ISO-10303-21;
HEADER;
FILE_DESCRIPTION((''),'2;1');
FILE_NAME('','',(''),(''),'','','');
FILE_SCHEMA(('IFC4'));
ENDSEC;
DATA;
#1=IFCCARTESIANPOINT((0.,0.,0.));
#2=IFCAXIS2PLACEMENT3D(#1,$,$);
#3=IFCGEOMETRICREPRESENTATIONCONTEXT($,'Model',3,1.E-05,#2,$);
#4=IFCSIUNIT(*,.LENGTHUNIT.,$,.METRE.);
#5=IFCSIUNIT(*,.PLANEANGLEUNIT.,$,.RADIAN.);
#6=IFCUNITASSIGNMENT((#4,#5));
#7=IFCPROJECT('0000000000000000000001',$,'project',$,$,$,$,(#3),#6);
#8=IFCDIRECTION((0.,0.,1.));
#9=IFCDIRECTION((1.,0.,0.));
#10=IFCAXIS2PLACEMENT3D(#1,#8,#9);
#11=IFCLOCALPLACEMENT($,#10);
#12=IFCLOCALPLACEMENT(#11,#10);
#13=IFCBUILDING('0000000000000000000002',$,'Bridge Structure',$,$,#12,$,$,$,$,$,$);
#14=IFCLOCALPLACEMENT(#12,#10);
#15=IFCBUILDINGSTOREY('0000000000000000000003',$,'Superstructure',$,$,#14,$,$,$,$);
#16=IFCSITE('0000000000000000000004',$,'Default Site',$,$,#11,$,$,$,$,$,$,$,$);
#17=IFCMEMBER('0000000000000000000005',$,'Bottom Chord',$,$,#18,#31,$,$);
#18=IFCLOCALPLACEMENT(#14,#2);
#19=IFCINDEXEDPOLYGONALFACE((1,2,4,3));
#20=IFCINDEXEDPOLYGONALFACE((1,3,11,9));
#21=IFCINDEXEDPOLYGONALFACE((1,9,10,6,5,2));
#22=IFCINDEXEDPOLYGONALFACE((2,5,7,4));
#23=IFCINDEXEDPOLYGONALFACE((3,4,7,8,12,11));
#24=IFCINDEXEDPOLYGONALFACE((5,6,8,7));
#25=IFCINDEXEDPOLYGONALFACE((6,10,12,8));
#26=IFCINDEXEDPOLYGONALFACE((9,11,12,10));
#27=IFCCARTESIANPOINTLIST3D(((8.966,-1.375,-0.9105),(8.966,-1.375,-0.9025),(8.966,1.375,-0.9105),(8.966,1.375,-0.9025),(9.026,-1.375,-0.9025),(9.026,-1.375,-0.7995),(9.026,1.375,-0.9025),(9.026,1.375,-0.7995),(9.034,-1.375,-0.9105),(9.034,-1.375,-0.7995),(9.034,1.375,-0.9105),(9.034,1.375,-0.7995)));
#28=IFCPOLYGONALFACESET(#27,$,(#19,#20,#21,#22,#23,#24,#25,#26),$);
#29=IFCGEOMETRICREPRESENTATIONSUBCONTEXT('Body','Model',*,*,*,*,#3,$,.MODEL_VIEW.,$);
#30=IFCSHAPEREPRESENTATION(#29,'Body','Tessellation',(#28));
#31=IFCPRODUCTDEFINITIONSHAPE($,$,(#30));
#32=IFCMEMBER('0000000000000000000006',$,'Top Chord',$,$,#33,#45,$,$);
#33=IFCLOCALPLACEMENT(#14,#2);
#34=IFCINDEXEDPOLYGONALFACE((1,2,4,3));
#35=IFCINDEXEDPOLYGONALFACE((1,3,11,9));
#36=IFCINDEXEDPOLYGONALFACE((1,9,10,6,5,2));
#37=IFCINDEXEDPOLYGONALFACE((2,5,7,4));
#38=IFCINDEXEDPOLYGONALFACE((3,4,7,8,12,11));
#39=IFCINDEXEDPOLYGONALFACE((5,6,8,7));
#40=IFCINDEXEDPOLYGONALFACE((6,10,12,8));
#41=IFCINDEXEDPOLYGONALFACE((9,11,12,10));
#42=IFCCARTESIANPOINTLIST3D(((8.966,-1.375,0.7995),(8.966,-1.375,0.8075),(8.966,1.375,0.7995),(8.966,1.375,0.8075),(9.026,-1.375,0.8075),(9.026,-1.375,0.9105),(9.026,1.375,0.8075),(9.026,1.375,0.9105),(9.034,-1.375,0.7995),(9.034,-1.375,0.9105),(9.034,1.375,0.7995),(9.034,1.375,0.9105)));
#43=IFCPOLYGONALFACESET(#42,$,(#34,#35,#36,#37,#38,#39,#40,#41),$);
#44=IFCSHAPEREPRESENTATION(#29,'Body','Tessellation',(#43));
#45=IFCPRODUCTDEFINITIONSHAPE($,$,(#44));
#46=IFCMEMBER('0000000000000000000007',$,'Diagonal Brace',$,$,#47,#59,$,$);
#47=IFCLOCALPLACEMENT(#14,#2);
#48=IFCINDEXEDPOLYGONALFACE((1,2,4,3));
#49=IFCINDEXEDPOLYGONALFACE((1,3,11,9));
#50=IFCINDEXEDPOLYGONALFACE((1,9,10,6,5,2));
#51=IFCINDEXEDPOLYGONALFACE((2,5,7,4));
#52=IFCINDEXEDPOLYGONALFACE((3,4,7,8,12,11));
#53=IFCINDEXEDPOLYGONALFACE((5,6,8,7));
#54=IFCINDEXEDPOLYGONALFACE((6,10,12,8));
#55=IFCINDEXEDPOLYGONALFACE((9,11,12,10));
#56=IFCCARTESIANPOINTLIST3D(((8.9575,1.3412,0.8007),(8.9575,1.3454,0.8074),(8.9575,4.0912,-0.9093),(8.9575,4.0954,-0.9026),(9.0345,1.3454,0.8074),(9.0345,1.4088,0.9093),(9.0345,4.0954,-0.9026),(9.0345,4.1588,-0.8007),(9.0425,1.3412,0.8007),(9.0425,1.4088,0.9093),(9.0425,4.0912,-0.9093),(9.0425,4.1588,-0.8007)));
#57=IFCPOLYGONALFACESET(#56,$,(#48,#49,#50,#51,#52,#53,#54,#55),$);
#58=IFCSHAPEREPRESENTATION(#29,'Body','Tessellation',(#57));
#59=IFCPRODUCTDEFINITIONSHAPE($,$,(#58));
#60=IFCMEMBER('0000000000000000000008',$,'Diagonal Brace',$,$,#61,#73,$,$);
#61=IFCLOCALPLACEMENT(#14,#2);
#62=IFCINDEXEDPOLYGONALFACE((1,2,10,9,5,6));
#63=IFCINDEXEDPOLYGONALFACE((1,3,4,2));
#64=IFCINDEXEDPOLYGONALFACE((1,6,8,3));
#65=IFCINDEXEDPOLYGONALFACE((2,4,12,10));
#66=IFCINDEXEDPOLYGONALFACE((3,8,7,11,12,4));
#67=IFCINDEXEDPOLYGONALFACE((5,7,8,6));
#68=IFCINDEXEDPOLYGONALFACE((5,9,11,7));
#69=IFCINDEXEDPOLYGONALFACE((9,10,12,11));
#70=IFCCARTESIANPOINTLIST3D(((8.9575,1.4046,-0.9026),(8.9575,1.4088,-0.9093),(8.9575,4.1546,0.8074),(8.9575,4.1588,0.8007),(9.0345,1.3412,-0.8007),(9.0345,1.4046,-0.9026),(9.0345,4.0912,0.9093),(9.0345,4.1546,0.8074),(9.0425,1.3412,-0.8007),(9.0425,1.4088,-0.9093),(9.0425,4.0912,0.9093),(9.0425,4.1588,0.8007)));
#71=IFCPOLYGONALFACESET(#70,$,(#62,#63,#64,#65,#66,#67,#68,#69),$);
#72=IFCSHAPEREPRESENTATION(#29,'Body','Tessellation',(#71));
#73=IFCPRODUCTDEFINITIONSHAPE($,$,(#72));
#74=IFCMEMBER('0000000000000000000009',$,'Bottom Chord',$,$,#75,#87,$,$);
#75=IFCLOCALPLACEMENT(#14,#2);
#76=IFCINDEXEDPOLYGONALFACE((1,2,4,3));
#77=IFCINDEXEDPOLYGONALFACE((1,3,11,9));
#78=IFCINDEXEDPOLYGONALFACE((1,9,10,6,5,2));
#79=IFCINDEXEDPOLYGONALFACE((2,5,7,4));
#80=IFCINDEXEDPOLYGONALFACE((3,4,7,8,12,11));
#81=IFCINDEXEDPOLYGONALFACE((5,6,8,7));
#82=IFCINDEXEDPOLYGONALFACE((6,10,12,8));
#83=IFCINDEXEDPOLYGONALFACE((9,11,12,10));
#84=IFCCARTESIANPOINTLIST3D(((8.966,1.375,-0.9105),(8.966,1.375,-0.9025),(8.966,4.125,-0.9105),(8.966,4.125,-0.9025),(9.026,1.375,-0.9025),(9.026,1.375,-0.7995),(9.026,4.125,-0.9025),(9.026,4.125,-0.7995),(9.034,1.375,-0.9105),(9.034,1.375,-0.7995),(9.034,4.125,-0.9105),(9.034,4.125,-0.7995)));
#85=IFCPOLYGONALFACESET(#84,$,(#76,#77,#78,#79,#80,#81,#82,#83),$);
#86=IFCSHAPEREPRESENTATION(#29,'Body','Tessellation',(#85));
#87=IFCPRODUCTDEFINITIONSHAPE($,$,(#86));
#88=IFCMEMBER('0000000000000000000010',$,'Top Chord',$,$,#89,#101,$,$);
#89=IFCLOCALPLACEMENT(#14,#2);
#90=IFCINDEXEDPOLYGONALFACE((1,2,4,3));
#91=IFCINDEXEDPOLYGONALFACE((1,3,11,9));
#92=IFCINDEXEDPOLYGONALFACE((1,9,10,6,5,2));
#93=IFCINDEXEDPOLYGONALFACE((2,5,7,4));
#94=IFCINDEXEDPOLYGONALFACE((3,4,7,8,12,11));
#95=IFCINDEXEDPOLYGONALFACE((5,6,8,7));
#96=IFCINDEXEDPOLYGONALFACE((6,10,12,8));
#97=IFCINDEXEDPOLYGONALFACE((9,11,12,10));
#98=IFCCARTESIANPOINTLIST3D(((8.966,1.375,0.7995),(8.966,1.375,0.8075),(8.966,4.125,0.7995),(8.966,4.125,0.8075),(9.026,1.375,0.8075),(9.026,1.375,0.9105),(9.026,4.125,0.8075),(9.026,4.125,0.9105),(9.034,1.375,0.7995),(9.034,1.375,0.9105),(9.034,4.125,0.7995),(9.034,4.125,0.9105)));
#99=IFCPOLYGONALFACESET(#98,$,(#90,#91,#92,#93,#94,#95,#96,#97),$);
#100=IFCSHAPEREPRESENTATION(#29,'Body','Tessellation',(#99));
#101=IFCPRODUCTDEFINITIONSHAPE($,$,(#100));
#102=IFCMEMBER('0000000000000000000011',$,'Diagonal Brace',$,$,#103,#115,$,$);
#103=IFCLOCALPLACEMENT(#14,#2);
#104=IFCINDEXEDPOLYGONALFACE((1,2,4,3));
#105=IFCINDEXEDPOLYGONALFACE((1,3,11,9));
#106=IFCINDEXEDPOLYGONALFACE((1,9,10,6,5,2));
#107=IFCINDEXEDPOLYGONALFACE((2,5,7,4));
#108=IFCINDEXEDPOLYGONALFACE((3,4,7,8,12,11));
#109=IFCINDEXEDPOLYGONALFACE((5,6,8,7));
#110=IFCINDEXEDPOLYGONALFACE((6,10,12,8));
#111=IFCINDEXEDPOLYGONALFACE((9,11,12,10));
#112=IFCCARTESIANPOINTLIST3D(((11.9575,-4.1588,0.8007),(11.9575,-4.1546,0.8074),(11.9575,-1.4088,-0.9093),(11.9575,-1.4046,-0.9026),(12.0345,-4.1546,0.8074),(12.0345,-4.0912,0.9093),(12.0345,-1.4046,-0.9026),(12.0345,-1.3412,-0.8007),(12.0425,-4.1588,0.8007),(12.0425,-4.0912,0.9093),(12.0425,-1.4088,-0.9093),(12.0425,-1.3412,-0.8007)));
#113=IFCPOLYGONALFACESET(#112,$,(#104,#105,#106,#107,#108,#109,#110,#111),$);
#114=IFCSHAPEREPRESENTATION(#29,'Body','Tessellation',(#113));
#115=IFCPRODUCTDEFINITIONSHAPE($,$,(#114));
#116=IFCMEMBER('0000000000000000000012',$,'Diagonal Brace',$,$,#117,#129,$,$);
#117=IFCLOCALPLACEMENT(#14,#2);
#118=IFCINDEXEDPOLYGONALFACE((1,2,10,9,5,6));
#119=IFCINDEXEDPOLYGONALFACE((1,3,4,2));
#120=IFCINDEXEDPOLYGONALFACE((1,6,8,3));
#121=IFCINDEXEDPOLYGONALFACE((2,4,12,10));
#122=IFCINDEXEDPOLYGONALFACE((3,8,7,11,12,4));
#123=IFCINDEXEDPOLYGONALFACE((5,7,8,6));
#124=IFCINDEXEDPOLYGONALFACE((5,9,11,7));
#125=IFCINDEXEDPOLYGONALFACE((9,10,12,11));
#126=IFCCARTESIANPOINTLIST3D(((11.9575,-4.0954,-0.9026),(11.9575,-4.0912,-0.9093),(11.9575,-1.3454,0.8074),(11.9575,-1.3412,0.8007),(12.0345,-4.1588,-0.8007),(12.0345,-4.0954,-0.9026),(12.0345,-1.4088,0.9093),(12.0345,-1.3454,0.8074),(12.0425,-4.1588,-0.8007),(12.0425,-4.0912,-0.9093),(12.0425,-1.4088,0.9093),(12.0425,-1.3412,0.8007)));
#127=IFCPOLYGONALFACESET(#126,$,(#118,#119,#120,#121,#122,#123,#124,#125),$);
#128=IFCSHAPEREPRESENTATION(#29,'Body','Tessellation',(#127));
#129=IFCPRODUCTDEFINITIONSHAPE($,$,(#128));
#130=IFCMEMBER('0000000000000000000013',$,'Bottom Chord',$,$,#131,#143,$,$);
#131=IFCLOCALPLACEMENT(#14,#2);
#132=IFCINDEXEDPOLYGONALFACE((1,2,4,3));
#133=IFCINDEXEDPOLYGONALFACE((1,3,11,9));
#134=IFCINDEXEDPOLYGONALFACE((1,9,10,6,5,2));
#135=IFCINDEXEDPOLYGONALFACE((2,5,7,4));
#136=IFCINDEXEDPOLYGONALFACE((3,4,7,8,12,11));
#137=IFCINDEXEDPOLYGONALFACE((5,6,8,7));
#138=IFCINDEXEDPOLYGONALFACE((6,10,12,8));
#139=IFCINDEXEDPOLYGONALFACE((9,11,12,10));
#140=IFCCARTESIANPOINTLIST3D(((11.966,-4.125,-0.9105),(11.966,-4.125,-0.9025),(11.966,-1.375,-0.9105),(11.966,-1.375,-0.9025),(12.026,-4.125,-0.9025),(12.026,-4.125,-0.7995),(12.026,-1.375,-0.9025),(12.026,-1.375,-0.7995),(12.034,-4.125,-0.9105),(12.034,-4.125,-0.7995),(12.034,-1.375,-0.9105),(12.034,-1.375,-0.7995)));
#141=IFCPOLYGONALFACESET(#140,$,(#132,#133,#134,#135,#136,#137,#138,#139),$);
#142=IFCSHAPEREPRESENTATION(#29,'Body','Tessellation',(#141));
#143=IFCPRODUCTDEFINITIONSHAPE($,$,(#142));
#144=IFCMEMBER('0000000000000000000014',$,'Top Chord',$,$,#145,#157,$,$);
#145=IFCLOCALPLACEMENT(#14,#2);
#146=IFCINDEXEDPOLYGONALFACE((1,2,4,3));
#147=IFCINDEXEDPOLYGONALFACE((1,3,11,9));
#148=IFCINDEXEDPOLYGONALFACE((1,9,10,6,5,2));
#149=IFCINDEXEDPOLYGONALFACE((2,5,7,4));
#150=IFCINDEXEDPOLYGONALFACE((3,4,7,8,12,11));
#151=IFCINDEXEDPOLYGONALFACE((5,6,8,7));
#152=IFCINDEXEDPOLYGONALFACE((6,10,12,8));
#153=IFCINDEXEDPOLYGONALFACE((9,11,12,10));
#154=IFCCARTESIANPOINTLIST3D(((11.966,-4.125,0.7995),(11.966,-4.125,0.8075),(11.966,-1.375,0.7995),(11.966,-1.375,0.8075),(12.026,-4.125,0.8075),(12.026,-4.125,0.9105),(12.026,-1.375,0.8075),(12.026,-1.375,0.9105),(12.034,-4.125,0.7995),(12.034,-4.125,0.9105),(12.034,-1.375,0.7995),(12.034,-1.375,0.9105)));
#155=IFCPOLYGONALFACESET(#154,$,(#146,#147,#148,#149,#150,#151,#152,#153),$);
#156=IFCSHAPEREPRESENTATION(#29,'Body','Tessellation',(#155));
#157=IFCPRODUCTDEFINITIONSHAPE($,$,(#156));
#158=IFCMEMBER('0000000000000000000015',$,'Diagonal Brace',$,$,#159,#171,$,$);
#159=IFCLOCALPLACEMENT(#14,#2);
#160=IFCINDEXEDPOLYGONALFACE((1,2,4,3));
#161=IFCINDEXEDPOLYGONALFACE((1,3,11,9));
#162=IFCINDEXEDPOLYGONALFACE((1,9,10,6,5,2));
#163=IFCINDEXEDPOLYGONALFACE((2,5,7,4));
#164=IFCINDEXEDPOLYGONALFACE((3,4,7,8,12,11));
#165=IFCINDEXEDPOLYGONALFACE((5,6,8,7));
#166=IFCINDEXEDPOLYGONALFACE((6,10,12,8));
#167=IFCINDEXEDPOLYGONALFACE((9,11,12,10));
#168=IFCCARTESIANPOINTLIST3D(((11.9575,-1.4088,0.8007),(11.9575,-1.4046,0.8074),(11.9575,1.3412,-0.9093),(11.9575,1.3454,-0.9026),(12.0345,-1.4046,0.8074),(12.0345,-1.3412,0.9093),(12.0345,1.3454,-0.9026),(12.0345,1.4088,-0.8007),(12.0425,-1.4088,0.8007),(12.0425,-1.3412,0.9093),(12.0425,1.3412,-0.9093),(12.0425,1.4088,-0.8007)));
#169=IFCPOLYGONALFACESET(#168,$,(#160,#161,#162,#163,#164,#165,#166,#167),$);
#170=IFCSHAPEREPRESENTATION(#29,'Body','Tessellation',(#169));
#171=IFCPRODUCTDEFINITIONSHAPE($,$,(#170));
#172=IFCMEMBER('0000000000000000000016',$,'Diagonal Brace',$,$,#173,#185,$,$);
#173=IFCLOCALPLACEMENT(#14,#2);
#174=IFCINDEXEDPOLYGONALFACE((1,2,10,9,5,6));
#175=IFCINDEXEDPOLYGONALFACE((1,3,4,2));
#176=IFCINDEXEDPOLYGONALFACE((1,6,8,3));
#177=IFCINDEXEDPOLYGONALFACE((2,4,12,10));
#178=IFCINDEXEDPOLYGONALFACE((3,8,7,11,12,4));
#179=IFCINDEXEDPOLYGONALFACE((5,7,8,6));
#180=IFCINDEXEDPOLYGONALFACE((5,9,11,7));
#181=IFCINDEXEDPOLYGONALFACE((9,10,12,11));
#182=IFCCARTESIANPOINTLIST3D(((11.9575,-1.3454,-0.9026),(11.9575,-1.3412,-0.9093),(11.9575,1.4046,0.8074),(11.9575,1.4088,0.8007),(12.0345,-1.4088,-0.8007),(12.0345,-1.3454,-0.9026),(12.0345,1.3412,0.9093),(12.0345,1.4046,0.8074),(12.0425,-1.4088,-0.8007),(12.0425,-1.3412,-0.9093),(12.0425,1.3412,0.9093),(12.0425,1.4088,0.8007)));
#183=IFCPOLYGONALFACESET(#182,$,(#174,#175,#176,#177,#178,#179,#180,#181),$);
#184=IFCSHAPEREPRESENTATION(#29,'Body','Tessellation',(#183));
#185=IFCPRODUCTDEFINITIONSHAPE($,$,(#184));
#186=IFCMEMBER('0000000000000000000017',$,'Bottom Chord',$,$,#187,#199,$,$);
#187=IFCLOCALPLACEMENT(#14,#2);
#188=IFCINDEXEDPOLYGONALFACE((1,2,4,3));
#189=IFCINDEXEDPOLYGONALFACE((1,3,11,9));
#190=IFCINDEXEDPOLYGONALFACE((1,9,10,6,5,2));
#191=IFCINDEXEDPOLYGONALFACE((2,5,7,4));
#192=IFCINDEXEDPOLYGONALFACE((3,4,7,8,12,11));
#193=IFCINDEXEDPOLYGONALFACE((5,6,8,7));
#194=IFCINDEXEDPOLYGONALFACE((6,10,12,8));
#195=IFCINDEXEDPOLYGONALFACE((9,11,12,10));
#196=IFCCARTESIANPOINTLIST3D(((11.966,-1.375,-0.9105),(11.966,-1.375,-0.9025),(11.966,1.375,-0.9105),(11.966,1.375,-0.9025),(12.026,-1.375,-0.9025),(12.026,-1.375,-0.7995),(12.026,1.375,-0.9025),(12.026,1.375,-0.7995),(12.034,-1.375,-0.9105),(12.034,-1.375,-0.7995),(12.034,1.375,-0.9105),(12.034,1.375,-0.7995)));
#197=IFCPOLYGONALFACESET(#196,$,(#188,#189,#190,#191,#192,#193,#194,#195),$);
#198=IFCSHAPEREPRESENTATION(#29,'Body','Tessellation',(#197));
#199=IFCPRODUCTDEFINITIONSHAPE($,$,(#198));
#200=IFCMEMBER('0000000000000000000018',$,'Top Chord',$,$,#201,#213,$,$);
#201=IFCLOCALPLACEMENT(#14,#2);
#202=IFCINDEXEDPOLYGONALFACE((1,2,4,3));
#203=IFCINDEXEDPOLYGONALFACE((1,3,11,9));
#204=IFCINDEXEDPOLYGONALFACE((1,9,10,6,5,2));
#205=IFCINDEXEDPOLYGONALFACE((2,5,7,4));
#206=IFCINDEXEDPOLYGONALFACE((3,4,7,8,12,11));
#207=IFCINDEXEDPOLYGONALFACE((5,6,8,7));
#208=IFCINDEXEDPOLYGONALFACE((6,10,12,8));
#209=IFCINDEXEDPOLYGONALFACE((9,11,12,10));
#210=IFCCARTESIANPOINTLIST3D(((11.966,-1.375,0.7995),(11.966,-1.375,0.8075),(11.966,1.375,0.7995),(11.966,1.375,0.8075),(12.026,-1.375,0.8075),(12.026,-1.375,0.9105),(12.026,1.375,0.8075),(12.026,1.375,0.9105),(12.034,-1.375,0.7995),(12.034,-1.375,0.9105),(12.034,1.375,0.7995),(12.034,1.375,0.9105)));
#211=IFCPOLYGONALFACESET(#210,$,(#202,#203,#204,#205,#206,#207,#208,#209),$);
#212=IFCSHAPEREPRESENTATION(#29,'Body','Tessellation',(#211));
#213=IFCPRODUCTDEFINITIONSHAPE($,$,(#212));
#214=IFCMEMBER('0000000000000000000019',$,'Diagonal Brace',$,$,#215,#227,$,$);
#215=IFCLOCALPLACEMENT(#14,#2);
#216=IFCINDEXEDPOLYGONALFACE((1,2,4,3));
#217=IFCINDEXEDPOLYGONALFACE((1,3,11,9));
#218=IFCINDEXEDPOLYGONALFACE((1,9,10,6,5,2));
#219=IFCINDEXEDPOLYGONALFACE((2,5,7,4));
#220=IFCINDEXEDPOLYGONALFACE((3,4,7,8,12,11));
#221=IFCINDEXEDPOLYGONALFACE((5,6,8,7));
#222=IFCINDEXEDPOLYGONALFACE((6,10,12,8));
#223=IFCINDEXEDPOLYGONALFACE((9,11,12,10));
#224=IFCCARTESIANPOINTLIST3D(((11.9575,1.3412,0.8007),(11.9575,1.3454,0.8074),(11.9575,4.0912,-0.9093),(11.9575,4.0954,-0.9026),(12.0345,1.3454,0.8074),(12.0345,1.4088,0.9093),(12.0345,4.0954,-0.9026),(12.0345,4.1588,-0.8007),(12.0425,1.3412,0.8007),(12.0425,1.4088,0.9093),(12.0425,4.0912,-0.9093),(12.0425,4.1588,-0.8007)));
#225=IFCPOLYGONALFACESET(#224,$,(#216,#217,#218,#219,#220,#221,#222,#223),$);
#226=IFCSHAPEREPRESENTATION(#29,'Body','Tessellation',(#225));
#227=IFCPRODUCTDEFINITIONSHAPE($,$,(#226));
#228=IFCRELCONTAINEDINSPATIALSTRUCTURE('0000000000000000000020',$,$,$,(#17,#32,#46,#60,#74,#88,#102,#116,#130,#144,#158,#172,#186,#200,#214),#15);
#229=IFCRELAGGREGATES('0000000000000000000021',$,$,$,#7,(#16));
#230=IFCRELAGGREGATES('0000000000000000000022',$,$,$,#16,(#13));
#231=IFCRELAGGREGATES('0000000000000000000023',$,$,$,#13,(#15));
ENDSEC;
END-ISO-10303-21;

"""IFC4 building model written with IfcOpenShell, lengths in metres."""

from ifc_helpers import new_model, si_unit, frame, origin, origin_with_axes, origin_2d_with_axis, place, context, subcontext, project, spatial, l_section, extrude, element, save


model = new_model("IFC4")

# Units and contexts
model_context = context("Model", 3, precision=1e-05, world=origin())
body_context = subcontext(model_context, "Body", "Model", "MODEL_VIEW")
ifc_project = project(units=[si_unit("LENGTHUNIT", "METRE"), si_unit("PLANEANGLEUNIT", "RADIAN")], contexts=[model_context])

# Site, building, storey
site_placement = place(None, origin_with_axes())
site = spatial("IfcSite", under=ifc_project, at=site_placement, Name="Default Site")
building_placement = place(site_placement, origin_with_axes())
building = spatial("IfcBuilding", under=site, at=building_placement, Name="Bridge Structure")
storey_placement = place(building_placement, origin_with_axes())
storey = spatial("IfcBuildingStorey", under=building, at=storey_placement, Name="Superstructure")

# Members
for number, where, z_axis, x_axis, name in (
    (1, (9.0, -1.375, -0.855), (0.0, 1.0, 0.0), (-1.0, 0.0, 0.0), "Bottom Chord"),
    (2, (9.0, -1.375, 0.855), (0.0, 1.0, 0.0), (-1.0, 0.0, 0.0), "Top Chord"),
):
    element("IfcMember", number, at=place(storey_placement, frame(where, z_axis=z_axis, x_axis=x_axis)), inside=storey, Name=name, context=body_context, shape_type="SweptSolid", body=[
        extrude(l_section(Depth=0.111, Width=0.068, Thickness=0.008, at=origin_2d_with_axis()), origin_with_axes(), (0.0, 0.0, 1.0), 2.75),
    ])
for number, where, z_axis, x_axis, name in (
    (3, (9.0, 1.375, 0.855), (0.0, 0.84921, -0.528055), (-1.0, 0.0, 0.0), "Diagonal Brace"),
    (4, (9.0, 1.375, -0.855), (0.0, 0.84921, 0.528055), (-1.0, 0.0, 0.0), "Diagonal Brace"),
):
    element("IfcMember", number, at=place(storey_placement, frame(where, z_axis=z_axis, x_axis=x_axis)), inside=storey, Name=name, context=body_context, shape_type="SweptSolid", body=[
        extrude(l_section(Depth=0.128, Width=0.085, Thickness=0.008, at=origin_2d_with_axis()), origin_with_axes(), (0.0, 0.0, 1.0), 3.2383),
    ])
for number, where, z_axis, x_axis, name in (
    (5, (9.0, 1.375, -0.855), (0.0, 1.0, 0.0), (-1.0, 0.0, 0.0), "Bottom Chord"),
    (6, (9.0, 1.375, 0.855), (0.0, 1.0, 0.0), (-1.0, 0.0, 0.0), "Top Chord"),
):
    element("IfcMember", number, at=place(storey_placement, frame(where, z_axis=z_axis, x_axis=x_axis)), inside=storey, Name=name, context=body_context, shape_type="SweptSolid", body=[
        extrude(l_section(Depth=0.111, Width=0.068, Thickness=0.008, at=origin_2d_with_axis()), origin_with_axes(), (0.0, 0.0, 1.0), 2.75),
    ])
for number, where, z_axis, x_axis, name in (
    (7, (12.0, -4.125, 0.855), (0.0, 0.84921, -0.528055), (-1.0, 0.0, 0.0), "Diagonal Brace"),
    (8, (12.0, -4.125, -0.855), (0.0, 0.84921, 0.528055), (-1.0, 0.0, 0.0), "Diagonal Brace"),
):
    element("IfcMember", number, at=place(storey_placement, frame(where, z_axis=z_axis, x_axis=x_axis)), inside=storey, Name=name, context=body_context, shape_type="SweptSolid", body=[
        extrude(l_section(Depth=0.128, Width=0.085, Thickness=0.008, at=origin_2d_with_axis()), origin_with_axes(), (0.0, 0.0, 1.0), 3.2383),
    ])
for number, where, z_axis, x_axis, name in (
    (9, (12.0, -4.125, -0.855), (0.0, 1.0, 0.0), (-1.0, 0.0, 0.0), "Bottom Chord"),
    (10, (12.0, -4.125, 0.855), (0.0, 1.0, 0.0), (-1.0, 0.0, 0.0), "Top Chord"),
):
    element("IfcMember", number, at=place(storey_placement, frame(where, z_axis=z_axis, x_axis=x_axis)), inside=storey, Name=name, context=body_context, shape_type="SweptSolid", body=[
        extrude(l_section(Depth=0.111, Width=0.068, Thickness=0.008, at=origin_2d_with_axis()), origin_with_axes(), (0.0, 0.0, 1.0), 2.75),
    ])
for number, where, z_axis, x_axis, name in (
    (11, (12.0, -1.375, 0.855), (0.0, 0.84921, -0.528055), (-1.0, 0.0, 0.0), "Diagonal Brace"),
    (12, (12.0, -1.375, -0.855), (0.0, 0.84921, 0.528055), (-1.0, 0.0, 0.0), "Diagonal Brace"),
):
    element("IfcMember", number, at=place(storey_placement, frame(where, z_axis=z_axis, x_axis=x_axis)), inside=storey, Name=name, context=body_context, shape_type="SweptSolid", body=[
        extrude(l_section(Depth=0.128, Width=0.085, Thickness=0.008, at=origin_2d_with_axis()), origin_with_axes(), (0.0, 0.0, 1.0), 3.2383),
    ])
for number, where, z_axis, x_axis, name in (
    (13, (12.0, -1.375, -0.855), (0.0, 1.0, 0.0), (-1.0, 0.0, 0.0), "Bottom Chord"),
    (14, (12.0, -1.375, 0.855), (0.0, 1.0, 0.0), (-1.0, 0.0, 0.0), "Top Chord"),
):
    element("IfcMember", number, at=place(storey_placement, frame(where, z_axis=z_axis, x_axis=x_axis)), inside=storey, Name=name, context=body_context, shape_type="SweptSolid", body=[
        extrude(l_section(Depth=0.111, Width=0.068, Thickness=0.008, at=origin_2d_with_axis()), origin_with_axes(), (0.0, 0.0, 1.0), 2.75),
    ])
for number, where, z_axis, x_axis, name in (
    (15, (12.0, 1.375, 0.855), (0.0, 0.84921, -0.528055), (-1.0, 0.0, 0.0), "Diagonal Brace"),
):
    element("IfcMember", number, at=place(storey_placement, frame(where, z_axis=z_axis, x_axis=x_axis)), inside=storey, Name=name, context=body_context, shape_type="SweptSolid", body=[
        extrude(l_section(Depth=0.128, Width=0.085, Thickness=0.008, at=origin_2d_with_axis()), origin_with_axes(), (0.0, 0.0, 1.0), 3.2383),
    ])

save(model, "model.ifc")
